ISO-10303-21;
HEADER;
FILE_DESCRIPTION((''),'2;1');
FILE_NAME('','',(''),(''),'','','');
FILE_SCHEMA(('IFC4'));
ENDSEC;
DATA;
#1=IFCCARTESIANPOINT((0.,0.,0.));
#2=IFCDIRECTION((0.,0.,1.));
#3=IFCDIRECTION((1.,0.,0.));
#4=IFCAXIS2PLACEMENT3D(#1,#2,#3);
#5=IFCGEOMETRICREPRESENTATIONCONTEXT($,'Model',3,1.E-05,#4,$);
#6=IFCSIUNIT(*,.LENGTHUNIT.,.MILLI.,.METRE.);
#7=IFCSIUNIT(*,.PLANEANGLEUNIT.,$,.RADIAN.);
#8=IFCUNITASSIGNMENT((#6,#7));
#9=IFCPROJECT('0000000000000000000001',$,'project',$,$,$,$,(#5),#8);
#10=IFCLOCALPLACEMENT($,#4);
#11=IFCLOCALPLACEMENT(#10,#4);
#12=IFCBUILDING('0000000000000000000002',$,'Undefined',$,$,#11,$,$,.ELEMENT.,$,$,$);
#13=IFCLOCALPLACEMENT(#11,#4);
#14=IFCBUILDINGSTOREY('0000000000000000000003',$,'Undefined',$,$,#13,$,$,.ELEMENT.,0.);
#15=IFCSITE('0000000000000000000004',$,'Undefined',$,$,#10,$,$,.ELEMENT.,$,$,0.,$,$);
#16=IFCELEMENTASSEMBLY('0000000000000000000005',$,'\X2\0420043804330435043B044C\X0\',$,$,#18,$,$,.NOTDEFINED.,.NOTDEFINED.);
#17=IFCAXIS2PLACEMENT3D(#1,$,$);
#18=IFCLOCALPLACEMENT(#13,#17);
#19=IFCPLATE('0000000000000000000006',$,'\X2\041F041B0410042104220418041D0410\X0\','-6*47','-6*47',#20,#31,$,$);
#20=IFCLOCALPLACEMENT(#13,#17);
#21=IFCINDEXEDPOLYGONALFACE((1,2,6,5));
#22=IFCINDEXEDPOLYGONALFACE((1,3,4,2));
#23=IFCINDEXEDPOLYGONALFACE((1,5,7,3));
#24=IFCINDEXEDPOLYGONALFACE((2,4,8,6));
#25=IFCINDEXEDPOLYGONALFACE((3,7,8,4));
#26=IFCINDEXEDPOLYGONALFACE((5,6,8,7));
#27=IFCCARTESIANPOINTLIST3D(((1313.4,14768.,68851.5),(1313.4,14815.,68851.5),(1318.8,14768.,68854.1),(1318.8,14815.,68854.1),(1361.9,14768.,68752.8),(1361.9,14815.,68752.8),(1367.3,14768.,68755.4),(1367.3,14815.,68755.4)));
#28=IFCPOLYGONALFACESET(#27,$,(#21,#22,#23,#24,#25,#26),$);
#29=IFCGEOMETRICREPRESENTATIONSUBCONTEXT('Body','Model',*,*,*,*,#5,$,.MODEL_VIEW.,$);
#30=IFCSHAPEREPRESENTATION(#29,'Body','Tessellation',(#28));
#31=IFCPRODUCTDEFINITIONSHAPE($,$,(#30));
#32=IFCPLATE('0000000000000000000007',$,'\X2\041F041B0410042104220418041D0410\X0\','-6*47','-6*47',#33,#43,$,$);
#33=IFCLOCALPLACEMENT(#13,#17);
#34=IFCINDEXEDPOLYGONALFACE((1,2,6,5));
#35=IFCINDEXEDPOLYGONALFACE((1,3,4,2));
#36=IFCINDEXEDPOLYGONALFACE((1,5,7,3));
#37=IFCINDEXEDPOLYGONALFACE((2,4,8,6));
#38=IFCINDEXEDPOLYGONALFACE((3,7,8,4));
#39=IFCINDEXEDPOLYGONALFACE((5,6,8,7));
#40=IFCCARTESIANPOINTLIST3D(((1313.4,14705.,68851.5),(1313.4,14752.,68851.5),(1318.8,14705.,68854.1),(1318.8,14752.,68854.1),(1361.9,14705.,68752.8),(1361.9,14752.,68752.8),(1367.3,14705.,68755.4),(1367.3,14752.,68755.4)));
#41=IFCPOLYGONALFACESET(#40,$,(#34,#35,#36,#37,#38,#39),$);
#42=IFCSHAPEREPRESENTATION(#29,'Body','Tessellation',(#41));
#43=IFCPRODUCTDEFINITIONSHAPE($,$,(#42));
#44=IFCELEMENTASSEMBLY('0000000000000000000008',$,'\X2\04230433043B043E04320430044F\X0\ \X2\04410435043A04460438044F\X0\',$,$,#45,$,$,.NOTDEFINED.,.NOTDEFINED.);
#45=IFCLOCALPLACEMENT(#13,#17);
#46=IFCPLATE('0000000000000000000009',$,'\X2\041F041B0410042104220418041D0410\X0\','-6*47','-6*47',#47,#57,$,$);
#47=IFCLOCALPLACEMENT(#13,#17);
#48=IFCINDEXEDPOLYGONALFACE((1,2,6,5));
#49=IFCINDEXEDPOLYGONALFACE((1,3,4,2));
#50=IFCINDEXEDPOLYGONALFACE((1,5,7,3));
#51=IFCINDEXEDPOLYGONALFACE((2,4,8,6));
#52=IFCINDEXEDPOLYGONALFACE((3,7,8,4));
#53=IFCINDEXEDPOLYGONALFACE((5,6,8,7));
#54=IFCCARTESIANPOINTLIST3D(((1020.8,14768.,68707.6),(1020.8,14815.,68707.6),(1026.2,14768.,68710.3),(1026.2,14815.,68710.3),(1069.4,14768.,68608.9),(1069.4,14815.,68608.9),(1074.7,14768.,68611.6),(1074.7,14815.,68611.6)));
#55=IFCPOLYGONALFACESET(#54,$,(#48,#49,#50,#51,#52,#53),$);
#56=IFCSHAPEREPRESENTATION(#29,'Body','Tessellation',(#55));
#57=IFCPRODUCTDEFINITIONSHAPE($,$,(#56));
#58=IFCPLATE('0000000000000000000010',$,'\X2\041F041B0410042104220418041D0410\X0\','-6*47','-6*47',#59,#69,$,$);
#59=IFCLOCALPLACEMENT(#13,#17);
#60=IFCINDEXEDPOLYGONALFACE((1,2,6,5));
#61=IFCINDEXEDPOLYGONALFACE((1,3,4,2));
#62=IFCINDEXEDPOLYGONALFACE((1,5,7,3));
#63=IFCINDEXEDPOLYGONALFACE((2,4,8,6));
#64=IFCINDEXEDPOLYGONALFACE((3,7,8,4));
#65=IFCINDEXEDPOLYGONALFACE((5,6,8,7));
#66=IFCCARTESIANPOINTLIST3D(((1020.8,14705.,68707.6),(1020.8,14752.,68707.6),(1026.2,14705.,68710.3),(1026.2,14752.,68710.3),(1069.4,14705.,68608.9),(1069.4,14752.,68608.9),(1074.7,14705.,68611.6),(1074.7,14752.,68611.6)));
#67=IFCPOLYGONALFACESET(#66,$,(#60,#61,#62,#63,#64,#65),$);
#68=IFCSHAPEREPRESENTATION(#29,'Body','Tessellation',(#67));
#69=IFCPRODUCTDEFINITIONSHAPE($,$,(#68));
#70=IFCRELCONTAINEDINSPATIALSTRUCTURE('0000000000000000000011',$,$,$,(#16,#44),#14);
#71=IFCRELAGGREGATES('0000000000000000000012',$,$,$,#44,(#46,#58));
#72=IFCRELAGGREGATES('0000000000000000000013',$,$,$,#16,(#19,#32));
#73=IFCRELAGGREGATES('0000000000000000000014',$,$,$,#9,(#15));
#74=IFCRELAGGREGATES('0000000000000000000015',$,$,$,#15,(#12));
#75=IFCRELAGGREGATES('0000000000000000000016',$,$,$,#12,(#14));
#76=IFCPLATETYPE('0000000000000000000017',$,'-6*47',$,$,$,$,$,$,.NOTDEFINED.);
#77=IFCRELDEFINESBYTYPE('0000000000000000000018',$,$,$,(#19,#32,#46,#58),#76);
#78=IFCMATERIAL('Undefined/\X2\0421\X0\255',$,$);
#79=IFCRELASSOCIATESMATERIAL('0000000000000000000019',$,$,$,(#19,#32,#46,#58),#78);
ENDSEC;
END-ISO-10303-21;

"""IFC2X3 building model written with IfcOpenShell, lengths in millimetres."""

from ifc_helpers import new_model, si_unit, frame, origin_with_axes, origin_2d_with_axis, place, context, subcontext, project, spatial, polyline, rectangle, outline, extrude, boolean, material, type_object, element, aggregate, save


model = new_model("IFC2X3")

# Units and contexts
model_context = context("Model", 3, precision=1e-05, world=origin_with_axes())
body_context = subcontext(model_context, "Body", "Model", "MODEL_VIEW")
ifc_project = project(units=[si_unit("LENGTHUNIT", "METRE", prefix="MILLI"), si_unit("PLANEANGLEUNIT", "RADIAN")], contexts=[model_context])

# Site, building, storey
site_placement = place(None, origin_with_axes())
site = spatial("IfcSite", under=ifc_project, at=site_placement, Name="Undefined", CompositionType="ELEMENT", RefElevation=0.0)
building_placement = place(site_placement, origin_with_axes())
building = spatial("IfcBuilding", under=site, at=building_placement, Name="Undefined", CompositionType="ELEMENT")
storey_placement = place(building_placement, origin_with_axes())
storey = spatial("IfcBuildingStorey", under=building, at=storey_placement, Name="Undefined", CompositionType="ELEMENT", Elevation=0.0)

# Element assembly
assembly_1_placement = place(storey_placement, origin_with_axes())
assembly_1 = element("IfcElementAssembly", 1, at=assembly_1_placement, inside=storey, Name="Ригель", AssemblyPlace="NOTDEFINED", PredefinedType="NOTDEFINED")
ifc_material_1 = material(Name="Undefined/С255")

# Plates
plate_type = type_object("IfcPlateType", Name="-6*47", PredefinedType="NOTDEFINED")
plate_1_placement = place(assembly_1_placement, frame((1364.6, 14705.0, 68754.1), z_axis=(-0.897399, 0.0, -0.441221), x_axis=(-0.441221, 0.0, 0.897399)))
plate_1 = element("IfcPlate", 2, at=plate_1_placement, type_object=plate_type, material=ifc_material_1, Name="ПЛАСТИНА", Description="-6*47", ObjectType="-6*47", context=body_context, shape_type="CSG", body=[
    boolean("DIFFERENCE", extrude(outline(polyline([(0.0, 0.0), (110.0, 0.0), (110.0, 110.0), (0.0, 110.0), (0.0, 0.0)])), frame((0.0, 0.0, -3.0), z_axis=(0.0, 0.0, 1.0), x_axis=(1.0, 0.0, 0.0)), (0.0, 0.0, 1.0), 6.0), extrude(rectangle(XDim=26.0, YDim=130.0, at=origin_2d_with_axis()), frame((55.0, -3.0, 0.0), z_axis=(0.0, 1.0, 0.0), x_axis=(0.0, 0.0, -1.0)), (0.0, 0.0, 1.0), 66.0)),
])
plate_2_placement = place(assembly_1_placement, frame((1364.6, 14705.0, 68754.1), z_axis=(-0.897399, 0.0, -0.441221), x_axis=(-0.441221, 0.0, 0.897399)))
plate_2 = element("IfcPlate", 3, at=plate_2_placement, type_object=plate_type, material=ifc_material_1, Name="ПЛАСТИНА", Description="-6*47", ObjectType="-6*47", context=body_context, shape_type="CSG", body=[
    boolean("DIFFERENCE", extrude(outline(polyline([(0.0, 0.0), (110.0, 0.0), (110.0, 110.0), (0.0, 110.0), (0.0, 0.0)])), frame((0.0, 0.0, -3.0), z_axis=(0.0, 0.0, 1.0), x_axis=(1.0, 0.0, 0.0)), (0.0, 0.0, 1.0), 6.0), extrude(rectangle(XDim=26.0, YDim=130.0, at=origin_2d_with_axis()), frame((55.0, 47.0, 0.0), z_axis=(0.0, 1.0, 0.0), x_axis=(0.0, 0.0, -1.0)), (0.0, 0.0, 1.0), 66.0)),
])

# Element assembly, plates
assembly_2_placement = place(storey_placement, origin_with_axes())
assembly_2 = element("IfcElementAssembly", 4, at=assembly_2_placement, inside=storey, Name="Угловая секция", AssemblyPlace="NOTDEFINED", PredefinedType="NOTDEFINED")
plate_3_placement = place(assembly_2_placement, frame((1023.5, 14705.0, 68709.0), z_axis=(0.897399, 0.0, 0.441221), x_axis=(0.441221, 0.0, -0.897399)))
plate_3 = element("IfcPlate", 5, at=plate_3_placement, type_object=plate_type, material=ifc_material_1, Name="ПЛАСТИНА", Description="-6*47", ObjectType="-6*47", context=body_context, shape_type="CSG", body=[
    boolean("DIFFERENCE", extrude(outline(polyline([(0.0, 0.0), (110.0, 0.0), (110.0, 110.0), (0.0, 110.0), (0.0, 0.0)])), frame((0.0, 0.0, -3.0), z_axis=(0.0, 0.0, 1.0), x_axis=(1.0, 0.0, 0.0)), (0.0, 0.0, 1.0), 6.0), extrude(rectangle(XDim=26.0, YDim=130.0, at=origin_2d_with_axis()), frame((55.0, -3.0, 0.0), z_axis=(0.0, 1.0, 0.0), x_axis=(0.0, 0.0, -1.0)), (0.0, 0.0, 1.0), 66.0)),
])
plate_4_placement = place(assembly_2_placement, frame((1023.5, 14705.0, 68709.0), z_axis=(0.897399, 0.0, 0.441221), x_axis=(0.441221, 0.0, -0.897399)))
plate_4 = element("IfcPlate", 6, at=plate_4_placement, type_object=plate_type, material=ifc_material_1, Name="ПЛАСТИНА", Description="-6*47", ObjectType="-6*47", context=body_context, shape_type="CSG", body=[
    boolean("DIFFERENCE", extrude(outline(polyline([(0.0, 0.0), (110.0, 0.0), (110.0, 110.0), (0.0, 110.0), (0.0, 0.0)])), frame((0.0, 0.0, -3.0), z_axis=(0.0, 0.0, 1.0), x_axis=(1.0, 0.0, 0.0)), (0.0, 0.0, 1.0), 6.0), extrude(rectangle(XDim=26.0, YDim=130.0, at=origin_2d_with_axis()), frame((55.0, 47.0, 0.0), z_axis=(0.0, 1.0, 0.0), x_axis=(0.0, 0.0, -1.0)), (0.0, 0.0, 1.0), 66.0)),
])
aggregate(assembly_2, [plate_3, plate_4])

aggregate(assembly_1, [plate_1, plate_2])

save(model, "model.ifc")
